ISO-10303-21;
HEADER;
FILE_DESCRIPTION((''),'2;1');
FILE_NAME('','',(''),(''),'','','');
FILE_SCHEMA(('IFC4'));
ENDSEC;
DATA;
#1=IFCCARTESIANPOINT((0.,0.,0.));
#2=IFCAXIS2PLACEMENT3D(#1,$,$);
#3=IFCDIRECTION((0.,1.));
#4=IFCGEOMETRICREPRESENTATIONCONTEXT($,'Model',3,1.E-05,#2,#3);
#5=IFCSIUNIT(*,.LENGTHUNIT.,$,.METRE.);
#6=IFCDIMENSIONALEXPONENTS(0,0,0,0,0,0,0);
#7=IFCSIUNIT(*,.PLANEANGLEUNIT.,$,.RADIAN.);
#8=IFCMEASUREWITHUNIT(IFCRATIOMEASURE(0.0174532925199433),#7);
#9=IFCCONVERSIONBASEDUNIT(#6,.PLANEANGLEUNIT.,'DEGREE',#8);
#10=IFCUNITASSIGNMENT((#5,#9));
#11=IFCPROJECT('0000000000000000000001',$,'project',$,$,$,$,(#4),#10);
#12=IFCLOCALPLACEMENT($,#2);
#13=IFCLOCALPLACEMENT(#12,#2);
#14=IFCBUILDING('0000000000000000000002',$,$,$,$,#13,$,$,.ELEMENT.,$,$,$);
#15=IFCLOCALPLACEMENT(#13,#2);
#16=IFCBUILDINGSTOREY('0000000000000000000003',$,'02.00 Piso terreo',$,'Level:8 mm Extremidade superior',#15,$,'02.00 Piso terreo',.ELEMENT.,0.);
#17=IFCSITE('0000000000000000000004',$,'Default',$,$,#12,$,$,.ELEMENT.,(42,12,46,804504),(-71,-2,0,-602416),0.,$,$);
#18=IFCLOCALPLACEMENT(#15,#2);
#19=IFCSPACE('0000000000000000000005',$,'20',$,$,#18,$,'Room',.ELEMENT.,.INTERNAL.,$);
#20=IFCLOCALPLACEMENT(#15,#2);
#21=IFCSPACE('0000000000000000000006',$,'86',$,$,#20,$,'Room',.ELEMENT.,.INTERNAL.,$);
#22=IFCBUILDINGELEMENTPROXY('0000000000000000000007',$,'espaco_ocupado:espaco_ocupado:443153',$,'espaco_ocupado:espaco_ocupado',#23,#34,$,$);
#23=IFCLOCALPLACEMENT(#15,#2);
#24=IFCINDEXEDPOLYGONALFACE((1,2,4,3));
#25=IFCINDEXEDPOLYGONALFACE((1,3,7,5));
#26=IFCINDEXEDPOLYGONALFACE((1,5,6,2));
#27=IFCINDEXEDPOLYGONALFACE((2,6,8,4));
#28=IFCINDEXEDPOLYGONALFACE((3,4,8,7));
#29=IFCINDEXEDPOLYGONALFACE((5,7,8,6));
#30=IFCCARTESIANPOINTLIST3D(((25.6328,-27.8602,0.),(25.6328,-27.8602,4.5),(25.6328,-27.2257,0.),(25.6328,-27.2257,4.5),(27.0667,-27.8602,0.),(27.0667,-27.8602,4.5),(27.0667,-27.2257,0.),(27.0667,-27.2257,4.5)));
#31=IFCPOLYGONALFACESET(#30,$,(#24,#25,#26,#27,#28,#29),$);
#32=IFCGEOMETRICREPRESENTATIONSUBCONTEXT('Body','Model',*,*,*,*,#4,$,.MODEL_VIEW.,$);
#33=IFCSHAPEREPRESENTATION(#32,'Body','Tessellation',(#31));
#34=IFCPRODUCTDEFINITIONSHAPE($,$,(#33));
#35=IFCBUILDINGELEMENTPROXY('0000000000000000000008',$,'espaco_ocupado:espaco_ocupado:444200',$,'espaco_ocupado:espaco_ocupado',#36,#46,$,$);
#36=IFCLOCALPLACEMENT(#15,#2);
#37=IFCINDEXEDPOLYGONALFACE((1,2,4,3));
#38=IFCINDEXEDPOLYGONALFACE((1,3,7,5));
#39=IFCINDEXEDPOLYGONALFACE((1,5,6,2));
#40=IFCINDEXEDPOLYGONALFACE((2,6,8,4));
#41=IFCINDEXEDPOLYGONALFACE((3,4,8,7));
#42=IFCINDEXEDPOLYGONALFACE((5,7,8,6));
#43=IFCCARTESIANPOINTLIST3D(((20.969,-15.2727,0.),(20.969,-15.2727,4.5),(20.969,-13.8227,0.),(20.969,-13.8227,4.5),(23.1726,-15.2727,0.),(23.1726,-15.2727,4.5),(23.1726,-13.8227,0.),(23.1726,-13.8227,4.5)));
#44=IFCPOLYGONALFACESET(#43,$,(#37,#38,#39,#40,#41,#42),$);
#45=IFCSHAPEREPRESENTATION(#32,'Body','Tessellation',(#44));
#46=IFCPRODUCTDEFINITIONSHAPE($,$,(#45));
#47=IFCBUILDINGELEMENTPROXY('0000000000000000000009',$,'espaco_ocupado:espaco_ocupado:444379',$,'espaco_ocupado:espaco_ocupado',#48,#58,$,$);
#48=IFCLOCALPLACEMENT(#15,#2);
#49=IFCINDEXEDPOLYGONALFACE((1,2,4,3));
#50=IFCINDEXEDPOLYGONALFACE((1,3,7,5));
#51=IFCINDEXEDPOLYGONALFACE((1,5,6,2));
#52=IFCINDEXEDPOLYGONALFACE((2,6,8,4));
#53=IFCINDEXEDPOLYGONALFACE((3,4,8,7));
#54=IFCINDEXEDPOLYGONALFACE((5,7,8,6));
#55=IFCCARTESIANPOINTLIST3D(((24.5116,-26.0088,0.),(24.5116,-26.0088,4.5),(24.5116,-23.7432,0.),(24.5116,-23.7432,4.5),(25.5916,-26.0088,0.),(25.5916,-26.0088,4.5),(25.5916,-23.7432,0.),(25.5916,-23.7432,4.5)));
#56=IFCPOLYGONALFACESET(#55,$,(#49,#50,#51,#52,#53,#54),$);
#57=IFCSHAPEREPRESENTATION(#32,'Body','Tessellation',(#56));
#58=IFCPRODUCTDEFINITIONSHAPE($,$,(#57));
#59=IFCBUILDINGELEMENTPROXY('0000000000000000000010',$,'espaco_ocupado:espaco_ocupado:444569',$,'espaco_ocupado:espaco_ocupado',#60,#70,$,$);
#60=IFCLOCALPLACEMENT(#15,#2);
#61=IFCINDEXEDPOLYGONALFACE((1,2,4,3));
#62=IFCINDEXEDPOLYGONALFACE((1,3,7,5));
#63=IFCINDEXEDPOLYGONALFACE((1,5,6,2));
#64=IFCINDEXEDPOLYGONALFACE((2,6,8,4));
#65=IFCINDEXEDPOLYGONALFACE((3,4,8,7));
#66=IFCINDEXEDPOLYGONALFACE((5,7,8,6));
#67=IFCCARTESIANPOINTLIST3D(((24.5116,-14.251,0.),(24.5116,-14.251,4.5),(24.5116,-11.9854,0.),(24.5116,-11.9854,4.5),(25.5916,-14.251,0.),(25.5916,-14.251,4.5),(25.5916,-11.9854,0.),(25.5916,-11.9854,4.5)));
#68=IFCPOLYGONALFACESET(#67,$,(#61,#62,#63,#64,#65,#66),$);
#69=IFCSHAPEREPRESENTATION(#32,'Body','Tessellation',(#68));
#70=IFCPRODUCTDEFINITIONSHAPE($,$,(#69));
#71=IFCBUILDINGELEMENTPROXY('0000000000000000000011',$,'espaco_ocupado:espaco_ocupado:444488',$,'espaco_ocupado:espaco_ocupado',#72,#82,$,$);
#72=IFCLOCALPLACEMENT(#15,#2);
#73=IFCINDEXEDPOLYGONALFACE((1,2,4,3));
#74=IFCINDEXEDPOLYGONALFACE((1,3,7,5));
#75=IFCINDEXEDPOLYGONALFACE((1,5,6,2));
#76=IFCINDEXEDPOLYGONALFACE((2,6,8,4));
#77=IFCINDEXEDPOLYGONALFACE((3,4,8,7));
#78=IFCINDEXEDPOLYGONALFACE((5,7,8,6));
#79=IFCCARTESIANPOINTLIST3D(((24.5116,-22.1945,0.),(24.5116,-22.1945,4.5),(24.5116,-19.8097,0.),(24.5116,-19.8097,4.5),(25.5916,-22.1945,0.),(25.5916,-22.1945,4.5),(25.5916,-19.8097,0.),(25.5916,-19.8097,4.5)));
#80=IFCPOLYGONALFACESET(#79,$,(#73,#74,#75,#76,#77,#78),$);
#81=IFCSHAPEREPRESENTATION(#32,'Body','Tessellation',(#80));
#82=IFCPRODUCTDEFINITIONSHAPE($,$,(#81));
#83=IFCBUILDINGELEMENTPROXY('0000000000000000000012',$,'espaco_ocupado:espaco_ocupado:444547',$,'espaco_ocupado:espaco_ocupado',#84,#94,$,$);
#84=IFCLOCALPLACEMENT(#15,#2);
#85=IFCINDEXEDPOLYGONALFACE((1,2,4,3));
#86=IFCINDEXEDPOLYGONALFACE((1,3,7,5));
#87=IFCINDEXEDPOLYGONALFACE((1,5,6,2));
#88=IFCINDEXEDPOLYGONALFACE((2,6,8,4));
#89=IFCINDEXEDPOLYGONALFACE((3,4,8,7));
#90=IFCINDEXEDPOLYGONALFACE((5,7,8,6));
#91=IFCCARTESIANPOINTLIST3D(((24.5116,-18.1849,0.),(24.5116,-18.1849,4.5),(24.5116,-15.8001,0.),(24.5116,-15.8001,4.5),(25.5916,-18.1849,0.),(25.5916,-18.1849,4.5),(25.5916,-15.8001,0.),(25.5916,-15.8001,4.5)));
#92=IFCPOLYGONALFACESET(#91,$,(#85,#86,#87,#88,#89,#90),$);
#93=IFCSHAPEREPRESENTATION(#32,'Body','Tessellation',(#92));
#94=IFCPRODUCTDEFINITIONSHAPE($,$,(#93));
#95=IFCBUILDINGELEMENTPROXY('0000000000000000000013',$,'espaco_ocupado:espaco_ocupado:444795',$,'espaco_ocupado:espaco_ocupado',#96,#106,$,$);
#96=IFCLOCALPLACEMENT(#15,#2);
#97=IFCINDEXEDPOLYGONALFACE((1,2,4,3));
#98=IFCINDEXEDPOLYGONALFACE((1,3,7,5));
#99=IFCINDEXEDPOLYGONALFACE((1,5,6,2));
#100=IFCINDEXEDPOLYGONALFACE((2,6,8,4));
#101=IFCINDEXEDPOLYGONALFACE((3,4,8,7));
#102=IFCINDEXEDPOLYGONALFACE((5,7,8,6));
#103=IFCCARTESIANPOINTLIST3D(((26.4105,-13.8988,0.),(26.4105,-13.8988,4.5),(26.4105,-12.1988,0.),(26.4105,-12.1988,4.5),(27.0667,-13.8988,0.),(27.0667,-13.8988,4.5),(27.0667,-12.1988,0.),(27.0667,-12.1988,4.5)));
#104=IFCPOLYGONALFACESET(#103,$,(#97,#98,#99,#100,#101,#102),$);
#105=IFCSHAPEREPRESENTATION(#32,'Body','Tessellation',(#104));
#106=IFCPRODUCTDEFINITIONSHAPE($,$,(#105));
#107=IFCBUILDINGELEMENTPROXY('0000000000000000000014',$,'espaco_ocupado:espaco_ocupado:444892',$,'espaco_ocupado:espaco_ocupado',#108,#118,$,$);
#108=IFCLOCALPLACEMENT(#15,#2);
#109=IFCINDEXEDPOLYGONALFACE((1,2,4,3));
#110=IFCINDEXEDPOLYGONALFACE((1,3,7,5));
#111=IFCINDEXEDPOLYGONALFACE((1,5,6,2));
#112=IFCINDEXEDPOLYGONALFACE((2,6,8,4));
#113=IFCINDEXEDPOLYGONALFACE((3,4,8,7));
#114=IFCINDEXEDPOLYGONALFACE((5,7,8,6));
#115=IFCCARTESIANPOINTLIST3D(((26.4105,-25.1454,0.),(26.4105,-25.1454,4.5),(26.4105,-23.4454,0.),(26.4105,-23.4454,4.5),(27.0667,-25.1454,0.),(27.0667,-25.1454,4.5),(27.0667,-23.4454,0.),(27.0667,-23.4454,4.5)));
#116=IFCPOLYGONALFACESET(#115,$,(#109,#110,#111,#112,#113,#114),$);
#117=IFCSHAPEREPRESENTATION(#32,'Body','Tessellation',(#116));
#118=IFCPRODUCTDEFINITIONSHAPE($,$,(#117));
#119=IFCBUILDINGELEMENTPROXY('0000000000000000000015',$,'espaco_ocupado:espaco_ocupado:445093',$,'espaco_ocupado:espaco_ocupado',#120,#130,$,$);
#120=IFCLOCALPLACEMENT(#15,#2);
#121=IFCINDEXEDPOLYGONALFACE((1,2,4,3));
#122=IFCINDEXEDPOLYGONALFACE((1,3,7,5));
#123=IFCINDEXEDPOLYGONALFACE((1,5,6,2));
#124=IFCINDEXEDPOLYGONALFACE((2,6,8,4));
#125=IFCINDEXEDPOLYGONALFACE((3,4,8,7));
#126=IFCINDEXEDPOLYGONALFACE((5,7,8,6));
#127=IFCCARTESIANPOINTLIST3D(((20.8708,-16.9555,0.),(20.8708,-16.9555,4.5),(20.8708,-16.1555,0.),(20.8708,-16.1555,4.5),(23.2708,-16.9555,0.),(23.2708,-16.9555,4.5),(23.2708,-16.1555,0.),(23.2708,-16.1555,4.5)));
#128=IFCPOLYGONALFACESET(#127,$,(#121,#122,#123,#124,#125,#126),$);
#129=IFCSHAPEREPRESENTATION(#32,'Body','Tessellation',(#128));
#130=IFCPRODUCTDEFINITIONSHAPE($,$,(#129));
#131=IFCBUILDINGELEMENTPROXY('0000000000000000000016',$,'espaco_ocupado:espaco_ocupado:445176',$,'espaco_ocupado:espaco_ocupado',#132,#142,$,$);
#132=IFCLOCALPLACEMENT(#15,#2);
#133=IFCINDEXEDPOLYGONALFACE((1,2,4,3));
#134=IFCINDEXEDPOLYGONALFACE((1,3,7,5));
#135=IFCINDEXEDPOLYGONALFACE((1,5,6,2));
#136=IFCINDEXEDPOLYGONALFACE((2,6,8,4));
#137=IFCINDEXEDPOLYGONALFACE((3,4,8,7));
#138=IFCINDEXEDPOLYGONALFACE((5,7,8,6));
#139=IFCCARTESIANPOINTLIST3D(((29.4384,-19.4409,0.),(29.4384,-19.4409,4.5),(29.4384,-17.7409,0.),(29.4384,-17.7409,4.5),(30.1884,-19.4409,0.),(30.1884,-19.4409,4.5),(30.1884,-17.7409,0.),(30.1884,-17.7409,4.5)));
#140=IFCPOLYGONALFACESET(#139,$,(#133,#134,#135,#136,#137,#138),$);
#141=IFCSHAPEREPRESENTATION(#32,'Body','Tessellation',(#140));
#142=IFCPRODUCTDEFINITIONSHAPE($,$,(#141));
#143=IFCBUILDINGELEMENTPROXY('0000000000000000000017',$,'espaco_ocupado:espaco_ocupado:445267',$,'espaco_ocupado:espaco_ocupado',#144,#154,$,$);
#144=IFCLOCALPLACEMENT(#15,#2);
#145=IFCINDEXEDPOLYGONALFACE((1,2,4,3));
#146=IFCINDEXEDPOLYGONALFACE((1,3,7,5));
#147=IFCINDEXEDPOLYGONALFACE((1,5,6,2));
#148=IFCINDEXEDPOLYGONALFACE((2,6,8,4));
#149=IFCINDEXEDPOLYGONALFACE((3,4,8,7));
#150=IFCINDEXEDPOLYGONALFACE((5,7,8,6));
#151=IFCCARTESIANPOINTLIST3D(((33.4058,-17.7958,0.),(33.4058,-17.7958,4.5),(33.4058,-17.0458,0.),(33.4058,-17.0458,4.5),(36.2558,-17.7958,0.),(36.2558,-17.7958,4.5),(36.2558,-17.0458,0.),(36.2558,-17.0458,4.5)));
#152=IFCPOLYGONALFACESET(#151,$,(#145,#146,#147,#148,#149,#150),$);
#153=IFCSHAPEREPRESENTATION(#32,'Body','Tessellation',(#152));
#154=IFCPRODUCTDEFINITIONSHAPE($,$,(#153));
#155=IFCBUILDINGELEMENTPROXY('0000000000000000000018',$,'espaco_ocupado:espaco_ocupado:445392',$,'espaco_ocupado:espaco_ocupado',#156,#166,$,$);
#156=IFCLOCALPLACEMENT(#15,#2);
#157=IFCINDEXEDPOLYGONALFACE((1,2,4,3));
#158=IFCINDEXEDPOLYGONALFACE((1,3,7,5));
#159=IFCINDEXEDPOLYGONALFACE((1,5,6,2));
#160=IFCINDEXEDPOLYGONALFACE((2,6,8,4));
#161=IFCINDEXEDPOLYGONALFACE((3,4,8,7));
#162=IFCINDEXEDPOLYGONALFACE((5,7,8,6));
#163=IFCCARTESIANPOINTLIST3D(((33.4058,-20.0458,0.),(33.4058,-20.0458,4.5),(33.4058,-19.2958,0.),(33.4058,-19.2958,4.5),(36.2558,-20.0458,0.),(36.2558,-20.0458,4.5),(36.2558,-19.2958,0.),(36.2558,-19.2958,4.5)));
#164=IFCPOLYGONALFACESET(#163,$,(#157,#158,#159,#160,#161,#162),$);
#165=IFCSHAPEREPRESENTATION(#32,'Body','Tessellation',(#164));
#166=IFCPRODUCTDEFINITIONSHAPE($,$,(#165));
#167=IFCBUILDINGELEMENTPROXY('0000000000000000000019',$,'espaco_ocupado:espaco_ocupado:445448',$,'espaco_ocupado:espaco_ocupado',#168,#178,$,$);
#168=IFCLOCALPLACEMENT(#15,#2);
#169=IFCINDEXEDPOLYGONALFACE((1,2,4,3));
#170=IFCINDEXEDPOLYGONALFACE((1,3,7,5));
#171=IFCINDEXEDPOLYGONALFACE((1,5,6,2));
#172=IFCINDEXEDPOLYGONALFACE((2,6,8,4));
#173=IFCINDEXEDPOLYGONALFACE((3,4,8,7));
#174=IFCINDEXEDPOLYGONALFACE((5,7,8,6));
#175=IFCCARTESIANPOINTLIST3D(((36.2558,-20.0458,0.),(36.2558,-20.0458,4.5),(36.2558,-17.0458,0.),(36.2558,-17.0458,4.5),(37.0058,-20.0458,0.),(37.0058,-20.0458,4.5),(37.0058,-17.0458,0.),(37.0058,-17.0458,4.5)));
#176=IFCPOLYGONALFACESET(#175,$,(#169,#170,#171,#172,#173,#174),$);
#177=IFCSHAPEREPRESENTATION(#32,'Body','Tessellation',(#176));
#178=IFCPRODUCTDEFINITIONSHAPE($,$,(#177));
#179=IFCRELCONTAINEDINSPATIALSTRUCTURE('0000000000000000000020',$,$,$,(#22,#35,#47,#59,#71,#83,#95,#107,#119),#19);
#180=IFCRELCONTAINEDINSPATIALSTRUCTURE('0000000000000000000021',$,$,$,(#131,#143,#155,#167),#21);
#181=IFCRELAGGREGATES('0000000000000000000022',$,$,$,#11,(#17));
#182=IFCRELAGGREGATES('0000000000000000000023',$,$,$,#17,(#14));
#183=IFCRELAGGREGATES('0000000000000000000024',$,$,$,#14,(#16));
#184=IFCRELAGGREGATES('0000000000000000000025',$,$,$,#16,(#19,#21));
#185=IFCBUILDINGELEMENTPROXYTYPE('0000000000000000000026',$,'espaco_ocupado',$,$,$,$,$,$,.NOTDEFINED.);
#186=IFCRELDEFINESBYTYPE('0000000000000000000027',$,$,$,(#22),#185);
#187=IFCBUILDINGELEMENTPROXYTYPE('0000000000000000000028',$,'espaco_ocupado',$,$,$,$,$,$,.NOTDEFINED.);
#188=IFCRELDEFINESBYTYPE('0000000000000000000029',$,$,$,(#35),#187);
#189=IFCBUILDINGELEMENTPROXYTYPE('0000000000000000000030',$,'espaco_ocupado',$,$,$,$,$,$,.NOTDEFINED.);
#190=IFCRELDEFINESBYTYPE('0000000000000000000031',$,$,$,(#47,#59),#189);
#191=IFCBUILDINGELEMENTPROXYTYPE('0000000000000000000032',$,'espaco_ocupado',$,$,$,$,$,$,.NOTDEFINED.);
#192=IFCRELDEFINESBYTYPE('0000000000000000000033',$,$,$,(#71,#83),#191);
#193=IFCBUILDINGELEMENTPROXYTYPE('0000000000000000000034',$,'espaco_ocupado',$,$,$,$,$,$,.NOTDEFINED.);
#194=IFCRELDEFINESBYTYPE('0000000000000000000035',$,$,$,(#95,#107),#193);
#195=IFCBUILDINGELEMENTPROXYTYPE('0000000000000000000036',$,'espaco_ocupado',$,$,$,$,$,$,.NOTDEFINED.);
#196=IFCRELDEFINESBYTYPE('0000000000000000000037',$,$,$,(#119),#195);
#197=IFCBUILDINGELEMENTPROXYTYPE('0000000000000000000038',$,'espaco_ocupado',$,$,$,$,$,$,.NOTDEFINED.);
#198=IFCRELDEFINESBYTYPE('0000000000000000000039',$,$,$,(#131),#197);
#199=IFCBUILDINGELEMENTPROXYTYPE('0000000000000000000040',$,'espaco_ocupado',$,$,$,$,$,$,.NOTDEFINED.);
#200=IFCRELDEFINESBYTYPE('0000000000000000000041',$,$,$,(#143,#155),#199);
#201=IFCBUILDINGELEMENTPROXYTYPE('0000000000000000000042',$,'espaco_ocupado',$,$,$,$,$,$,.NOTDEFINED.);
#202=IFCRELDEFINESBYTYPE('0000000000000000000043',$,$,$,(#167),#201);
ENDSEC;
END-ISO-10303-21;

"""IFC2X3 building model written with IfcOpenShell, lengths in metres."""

from ifc_helpers import new_model, entity, si_unit, converted_unit, direction, frame, frame_2d, origin, origin_2d_with_axis, place, context, subcontext, project, spatial, rectangle, extrude, source, transform, mapped, type_object, type_shapes, element, save


model = new_model("IFC2X3")

# Units and contexts
model_context = context("Model", 3, precision=1e-05, world=origin(), true_north=direction((0.0, 1.0)))
body_context = subcontext(model_context, "Body", "Model", "MODEL_VIEW")
ifc_project = project(units=[si_unit("LENGTHUNIT", "METRE"), converted_unit("PLANEANGLEUNIT", "DEGREE", entity("IfcRatioMeasure", 0.0174532925199433), si_unit("PLANEANGLEUNIT", "RADIAN"), dimensions=[0, 0, 0, 0, 0, 0, 0])], contexts=[model_context])

# Site, building, storey
site_placement = place(None, origin())
site = spatial("IfcSite", under=ifc_project, at=site_placement, Name="Default", CompositionType="ELEMENT", RefLatitude=(42, 12, 46, 804504), RefLongitude=(-71, -2, 0, -602416), RefElevation=0.0)
building_placement = place(site_placement, origin())
building = spatial("IfcBuilding", under=site, at=building_placement, CompositionType="ELEMENT")
storey_placement = place(building_placement, origin())
storey = spatial("IfcBuildingStorey", under=building, at=storey_placement, Name="02.00 Piso terreo", ObjectType="Level:8 mm Extremidade superior", LongName="02.00 Piso terreo", CompositionType="ELEMENT", Elevation=0.0)

# Shared definitions
space_1_placement = place(storey_placement, origin())
space_1 = spatial("IfcSpace", under=storey, at=space_1_placement, Name="20", LongName="Room", CompositionType="ELEMENT", InteriorOrExteriorSpace="INTERNAL")

# Building element proxies
building_element_proxy_type_1 = type_object("IfcBuildingElementProxyType", Name="espaco_ocupado", PredefinedType="NOTDEFINED")
shared_shape_1 = source(origin(), body_context, "Body", "SweptSolid", [
    extrude(rectangle(XDim=1.4339, YDim=0.6345, at=origin_2d_with_axis()), frame((0.0, 0.0, 0.0), z_axis=(0.0, 0.0, 1.0), x_axis=(-1.0, 0.0, 0.0)), (0.0, 0.0, 1.0), 4.5),
])
type_shapes(building_element_proxy_type_1, [shared_shape_1])
proxy_1_placement = place(space_1_placement, frame((26.3497, -27.5429, 0.0)))
element("IfcBuildingElementProxy", 1, at=proxy_1_placement, inside=space_1, type_object=building_element_proxy_type_1, Name="espaco_ocupado:espaco_ocupado:443153", ObjectType="espaco_ocupado:espaco_ocupado", context=body_context, shape_type="MappedRepresentation", body=[
    mapped(shared_shape_1, transform((0.0, 0.0, 0.0), scale=1.0)),
])
building_element_proxy_type_2 = type_object("IfcBuildingElementProxyType", Name="espaco_ocupado", PredefinedType="NOTDEFINED")
shared_shape_2 = source(origin(), body_context, "Body", "SweptSolid", [
    extrude(rectangle(XDim=2.2036, YDim=1.45, at=origin_2d_with_axis()), frame((0.0, 0.0, 0.0), z_axis=(0.0, 0.0, 1.0), x_axis=(-1.0, 0.0, 0.0)), (0.0, 0.0, 1.0), 4.5),
])
type_shapes(building_element_proxy_type_2, [shared_shape_2])
proxy_2_placement = place(space_1_placement, frame((22.0708, -14.5477, 0.0)))
element("IfcBuildingElementProxy", 2, at=proxy_2_placement, inside=space_1, type_object=building_element_proxy_type_2, Name="espaco_ocupado:espaco_ocupado:444200", ObjectType="espaco_ocupado:espaco_ocupado", context=body_context, shape_type="MappedRepresentation", body=[
    mapped(shared_shape_2, transform((0.0, 0.0, 0.0), scale=1.0)),
])
building_element_proxy_type_3 = type_object("IfcBuildingElementProxyType", Name="espaco_ocupado", PredefinedType="NOTDEFINED")
shared_shape_3 = source(origin(), body_context, "Body", "SweptSolid", [
    extrude(rectangle(XDim=1.08, YDim=2.2656, at=origin_2d_with_axis()), frame((0.0, 0.0, 0.0), z_axis=(0.0, 0.0, 1.0), x_axis=(-1.0, 0.0, 0.0)), (0.0, 0.0, 1.0), 4.5),
])
type_shapes(building_element_proxy_type_3, [shared_shape_3])
for number, where, name in (
    (3, (25.0516, -24.876, 0.0), "espaco_ocupado:espaco_ocupado:444379"),
    (4, (25.0516, -13.1182, 0.0), "espaco_ocupado:espaco_ocupado:444569"),
):
    element("IfcBuildingElementProxy", number, at=place(space_1_placement, frame(where)), inside=space_1, type_object=building_element_proxy_type_3, Name=name, ObjectType="espaco_ocupado:espaco_ocupado", context=body_context, shape_type="MappedRepresentation", body=[
        mapped(shared_shape_3, transform((0.0, 0.0, 0.0), scale=1.0)),
    ])
building_element_proxy_type_4 = type_object("IfcBuildingElementProxyType", Name="espaco_ocupado", PredefinedType="NOTDEFINED")
shared_shape_4 = source(origin(), body_context, "Body", "SweptSolid", [
    extrude(rectangle(XDim=1.08, YDim=2.3848, at=origin_2d_with_axis()), frame((0.0, 0.0, 0.0), z_axis=(0.0, 0.0, 1.0), x_axis=(-1.0, 0.0, 0.0)), (0.0, 0.0, 1.0), 4.5),
])
type_shapes(building_element_proxy_type_4, [shared_shape_4])
for number, where, name in (
    (5, (25.0516, -21.0021, 0.0), "espaco_ocupado:espaco_ocupado:444488"),
    (6, (25.0516, -16.9925, 0.0), "espaco_ocupado:espaco_ocupado:444547"),
):
    element("IfcBuildingElementProxy", number, at=place(space_1_placement, frame(where)), inside=space_1, type_object=building_element_proxy_type_4, Name=name, ObjectType="espaco_ocupado:espaco_ocupado", context=body_context, shape_type="MappedRepresentation", body=[
        mapped(shared_shape_4, transform((0.0, 0.0, 0.0), scale=1.0)),
    ])
building_element_proxy_type_5 = type_object("IfcBuildingElementProxyType", Name="espaco_ocupado", PredefinedType="NOTDEFINED")
shared_shape_5 = source(origin(), body_context, "Body", "SweptSolid", [
    extrude(rectangle(XDim=0.6562, YDim=1.7, at=origin_2d_with_axis()), frame((0.0, 0.0, 0.0), z_axis=(0.0, 0.0, 1.0), x_axis=(-1.0, 0.0, 0.0)), (0.0, 0.0, 1.0), 4.5),
])
type_shapes(building_element_proxy_type_5, [shared_shape_5])
for number, where, name in (
    (7, (26.7386, -13.0488, 0.0), "espaco_ocupado:espaco_ocupado:444795"),
    (8, (26.7386, -24.2954, 0.0), "espaco_ocupado:espaco_ocupado:444892"),
):
    element("IfcBuildingElementProxy", number, at=place(space_1_placement, frame(where)), inside=space_1, type_object=building_element_proxy_type_5, Name=name, ObjectType="espaco_ocupado:espaco_ocupado", context=body_context, shape_type="MappedRepresentation", body=[
        mapped(shared_shape_5, transform((0.0, 0.0, 0.0), scale=1.0)),
    ])
building_element_proxy_type_6 = type_object("IfcBuildingElementProxyType", Name="espaco_ocupado", PredefinedType="NOTDEFINED")
shared_shape_6 = source(origin(), body_context, "Body", "SweptSolid", [
    extrude(rectangle(XDim=2.4, YDim=0.8, at=origin_2d_with_axis()), frame((0.0, 0.0, 0.0), z_axis=(0.0, 0.0, 1.0), x_axis=(-1.0, 0.0, 0.0)), (0.0, 0.0, 1.0), 4.5),
])
type_shapes(building_element_proxy_type_6, [shared_shape_6])
proxy_3_placement = place(space_1_placement, frame((22.0708, -16.5555, 0.0)))
element("IfcBuildingElementProxy", 9, at=proxy_3_placement, inside=space_1, type_object=building_element_proxy_type_6, Name="espaco_ocupado:espaco_ocupado:445093", ObjectType="espaco_ocupado:espaco_ocupado", context=body_context, shape_type="MappedRepresentation", body=[
    mapped(shared_shape_6, transform((0.0, 0.0, 0.0), scale=1.0)),
])

# Shared definitions
space_2_placement = place(storey_placement, origin())
space_2 = spatial("IfcSpace", under=storey, at=space_2_placement, Name="86", LongName="Room", CompositionType="ELEMENT", InteriorOrExteriorSpace="INTERNAL")

# Building element proxies
building_element_proxy_type_7 = type_object("IfcBuildingElementProxyType", Name="espaco_ocupado", PredefinedType="NOTDEFINED")
shared_shape_7 = source(origin(), body_context, "Body", "SweptSolid", [
    extrude(rectangle(XDim=0.75, YDim=1.7, at=frame_2d((0.0, 0.0), x_axis=(1.0, 0.0))), frame((0.0, 0.0, 0.0), z_axis=(0.0, 0.0, 1.0), x_axis=(-1.0, 0.0, 0.0)), (0.0, 0.0, 1.0), 4.5),
])
type_shapes(building_element_proxy_type_7, [shared_shape_7])
proxy_4_placement = place(space_2_placement, frame((29.8134, -18.5909, 0.0)))
element("IfcBuildingElementProxy", 10, at=proxy_4_placement, inside=space_2, type_object=building_element_proxy_type_7, Name="espaco_ocupado:espaco_ocupado:445176", ObjectType="espaco_ocupado:espaco_ocupado", context=body_context, shape_type="MappedRepresentation", body=[
    mapped(shared_shape_7, transform((0.0, 0.0, 0.0), scale=1.0)),
])
building_element_proxy_type_8 = type_object("IfcBuildingElementProxyType", Name="espaco_ocupado", PredefinedType="NOTDEFINED")
shared_shape_8 = source(origin(), body_context, "Body", "SweptSolid", [
    extrude(rectangle(XDim=2.85, YDim=0.75, at=origin_2d_with_axis()), frame((0.0, 0.0, 0.0), z_axis=(0.0, 0.0, 1.0), x_axis=(-1.0, 0.0, 0.0)), (0.0, 0.0, 1.0), 4.5),
])
type_shapes(building_element_proxy_type_8, [shared_shape_8])
for number, where, name in (
    (11, (34.8308, -17.4208, 0.0), "espaco_ocupado:espaco_ocupado:445267"),
    (12, (34.8308, -19.6708, 0.0), "espaco_ocupado:espaco_ocupado:445392"),
):
    element("IfcBuildingElementProxy", number, at=place(space_2_placement, frame(where)), inside=space_2, type_object=building_element_proxy_type_8, Name=name, ObjectType="espaco_ocupado:espaco_ocupado", context=body_context, shape_type="MappedRepresentation", body=[
        mapped(shared_shape_8, transform((0.0, 0.0, 0.0), scale=1.0)),
    ])
building_element_proxy_type_9 = type_object("IfcBuildingElementProxyType", Name="espaco_ocupado", PredefinedType="NOTDEFINED")
shared_shape_9 = source(origin(), body_context, "Body", "SweptSolid", [
    extrude(rectangle(XDim=0.75, YDim=3.0, at=origin_2d_with_axis()), frame((0.0, 0.0, 0.0), z_axis=(0.0, 0.0, 1.0), x_axis=(-1.0, 0.0, 0.0)), (0.0, 0.0, 1.0), 4.5),
])
type_shapes(building_element_proxy_type_9, [shared_shape_9])
proxy_5_placement = place(space_2_placement, frame((36.6308, -18.5458, 0.0)))
element("IfcBuildingElementProxy", 13, at=proxy_5_placement, inside=space_2, type_object=building_element_proxy_type_9, Name="espaco_ocupado:espaco_ocupado:445448", ObjectType="espaco_ocupado:espaco_ocupado", context=body_context, shape_type="MappedRepresentation", body=[
    mapped(shared_shape_9, transform((0.0, 0.0, 0.0), scale=1.0)),
])

save(model, "model.ifc")
